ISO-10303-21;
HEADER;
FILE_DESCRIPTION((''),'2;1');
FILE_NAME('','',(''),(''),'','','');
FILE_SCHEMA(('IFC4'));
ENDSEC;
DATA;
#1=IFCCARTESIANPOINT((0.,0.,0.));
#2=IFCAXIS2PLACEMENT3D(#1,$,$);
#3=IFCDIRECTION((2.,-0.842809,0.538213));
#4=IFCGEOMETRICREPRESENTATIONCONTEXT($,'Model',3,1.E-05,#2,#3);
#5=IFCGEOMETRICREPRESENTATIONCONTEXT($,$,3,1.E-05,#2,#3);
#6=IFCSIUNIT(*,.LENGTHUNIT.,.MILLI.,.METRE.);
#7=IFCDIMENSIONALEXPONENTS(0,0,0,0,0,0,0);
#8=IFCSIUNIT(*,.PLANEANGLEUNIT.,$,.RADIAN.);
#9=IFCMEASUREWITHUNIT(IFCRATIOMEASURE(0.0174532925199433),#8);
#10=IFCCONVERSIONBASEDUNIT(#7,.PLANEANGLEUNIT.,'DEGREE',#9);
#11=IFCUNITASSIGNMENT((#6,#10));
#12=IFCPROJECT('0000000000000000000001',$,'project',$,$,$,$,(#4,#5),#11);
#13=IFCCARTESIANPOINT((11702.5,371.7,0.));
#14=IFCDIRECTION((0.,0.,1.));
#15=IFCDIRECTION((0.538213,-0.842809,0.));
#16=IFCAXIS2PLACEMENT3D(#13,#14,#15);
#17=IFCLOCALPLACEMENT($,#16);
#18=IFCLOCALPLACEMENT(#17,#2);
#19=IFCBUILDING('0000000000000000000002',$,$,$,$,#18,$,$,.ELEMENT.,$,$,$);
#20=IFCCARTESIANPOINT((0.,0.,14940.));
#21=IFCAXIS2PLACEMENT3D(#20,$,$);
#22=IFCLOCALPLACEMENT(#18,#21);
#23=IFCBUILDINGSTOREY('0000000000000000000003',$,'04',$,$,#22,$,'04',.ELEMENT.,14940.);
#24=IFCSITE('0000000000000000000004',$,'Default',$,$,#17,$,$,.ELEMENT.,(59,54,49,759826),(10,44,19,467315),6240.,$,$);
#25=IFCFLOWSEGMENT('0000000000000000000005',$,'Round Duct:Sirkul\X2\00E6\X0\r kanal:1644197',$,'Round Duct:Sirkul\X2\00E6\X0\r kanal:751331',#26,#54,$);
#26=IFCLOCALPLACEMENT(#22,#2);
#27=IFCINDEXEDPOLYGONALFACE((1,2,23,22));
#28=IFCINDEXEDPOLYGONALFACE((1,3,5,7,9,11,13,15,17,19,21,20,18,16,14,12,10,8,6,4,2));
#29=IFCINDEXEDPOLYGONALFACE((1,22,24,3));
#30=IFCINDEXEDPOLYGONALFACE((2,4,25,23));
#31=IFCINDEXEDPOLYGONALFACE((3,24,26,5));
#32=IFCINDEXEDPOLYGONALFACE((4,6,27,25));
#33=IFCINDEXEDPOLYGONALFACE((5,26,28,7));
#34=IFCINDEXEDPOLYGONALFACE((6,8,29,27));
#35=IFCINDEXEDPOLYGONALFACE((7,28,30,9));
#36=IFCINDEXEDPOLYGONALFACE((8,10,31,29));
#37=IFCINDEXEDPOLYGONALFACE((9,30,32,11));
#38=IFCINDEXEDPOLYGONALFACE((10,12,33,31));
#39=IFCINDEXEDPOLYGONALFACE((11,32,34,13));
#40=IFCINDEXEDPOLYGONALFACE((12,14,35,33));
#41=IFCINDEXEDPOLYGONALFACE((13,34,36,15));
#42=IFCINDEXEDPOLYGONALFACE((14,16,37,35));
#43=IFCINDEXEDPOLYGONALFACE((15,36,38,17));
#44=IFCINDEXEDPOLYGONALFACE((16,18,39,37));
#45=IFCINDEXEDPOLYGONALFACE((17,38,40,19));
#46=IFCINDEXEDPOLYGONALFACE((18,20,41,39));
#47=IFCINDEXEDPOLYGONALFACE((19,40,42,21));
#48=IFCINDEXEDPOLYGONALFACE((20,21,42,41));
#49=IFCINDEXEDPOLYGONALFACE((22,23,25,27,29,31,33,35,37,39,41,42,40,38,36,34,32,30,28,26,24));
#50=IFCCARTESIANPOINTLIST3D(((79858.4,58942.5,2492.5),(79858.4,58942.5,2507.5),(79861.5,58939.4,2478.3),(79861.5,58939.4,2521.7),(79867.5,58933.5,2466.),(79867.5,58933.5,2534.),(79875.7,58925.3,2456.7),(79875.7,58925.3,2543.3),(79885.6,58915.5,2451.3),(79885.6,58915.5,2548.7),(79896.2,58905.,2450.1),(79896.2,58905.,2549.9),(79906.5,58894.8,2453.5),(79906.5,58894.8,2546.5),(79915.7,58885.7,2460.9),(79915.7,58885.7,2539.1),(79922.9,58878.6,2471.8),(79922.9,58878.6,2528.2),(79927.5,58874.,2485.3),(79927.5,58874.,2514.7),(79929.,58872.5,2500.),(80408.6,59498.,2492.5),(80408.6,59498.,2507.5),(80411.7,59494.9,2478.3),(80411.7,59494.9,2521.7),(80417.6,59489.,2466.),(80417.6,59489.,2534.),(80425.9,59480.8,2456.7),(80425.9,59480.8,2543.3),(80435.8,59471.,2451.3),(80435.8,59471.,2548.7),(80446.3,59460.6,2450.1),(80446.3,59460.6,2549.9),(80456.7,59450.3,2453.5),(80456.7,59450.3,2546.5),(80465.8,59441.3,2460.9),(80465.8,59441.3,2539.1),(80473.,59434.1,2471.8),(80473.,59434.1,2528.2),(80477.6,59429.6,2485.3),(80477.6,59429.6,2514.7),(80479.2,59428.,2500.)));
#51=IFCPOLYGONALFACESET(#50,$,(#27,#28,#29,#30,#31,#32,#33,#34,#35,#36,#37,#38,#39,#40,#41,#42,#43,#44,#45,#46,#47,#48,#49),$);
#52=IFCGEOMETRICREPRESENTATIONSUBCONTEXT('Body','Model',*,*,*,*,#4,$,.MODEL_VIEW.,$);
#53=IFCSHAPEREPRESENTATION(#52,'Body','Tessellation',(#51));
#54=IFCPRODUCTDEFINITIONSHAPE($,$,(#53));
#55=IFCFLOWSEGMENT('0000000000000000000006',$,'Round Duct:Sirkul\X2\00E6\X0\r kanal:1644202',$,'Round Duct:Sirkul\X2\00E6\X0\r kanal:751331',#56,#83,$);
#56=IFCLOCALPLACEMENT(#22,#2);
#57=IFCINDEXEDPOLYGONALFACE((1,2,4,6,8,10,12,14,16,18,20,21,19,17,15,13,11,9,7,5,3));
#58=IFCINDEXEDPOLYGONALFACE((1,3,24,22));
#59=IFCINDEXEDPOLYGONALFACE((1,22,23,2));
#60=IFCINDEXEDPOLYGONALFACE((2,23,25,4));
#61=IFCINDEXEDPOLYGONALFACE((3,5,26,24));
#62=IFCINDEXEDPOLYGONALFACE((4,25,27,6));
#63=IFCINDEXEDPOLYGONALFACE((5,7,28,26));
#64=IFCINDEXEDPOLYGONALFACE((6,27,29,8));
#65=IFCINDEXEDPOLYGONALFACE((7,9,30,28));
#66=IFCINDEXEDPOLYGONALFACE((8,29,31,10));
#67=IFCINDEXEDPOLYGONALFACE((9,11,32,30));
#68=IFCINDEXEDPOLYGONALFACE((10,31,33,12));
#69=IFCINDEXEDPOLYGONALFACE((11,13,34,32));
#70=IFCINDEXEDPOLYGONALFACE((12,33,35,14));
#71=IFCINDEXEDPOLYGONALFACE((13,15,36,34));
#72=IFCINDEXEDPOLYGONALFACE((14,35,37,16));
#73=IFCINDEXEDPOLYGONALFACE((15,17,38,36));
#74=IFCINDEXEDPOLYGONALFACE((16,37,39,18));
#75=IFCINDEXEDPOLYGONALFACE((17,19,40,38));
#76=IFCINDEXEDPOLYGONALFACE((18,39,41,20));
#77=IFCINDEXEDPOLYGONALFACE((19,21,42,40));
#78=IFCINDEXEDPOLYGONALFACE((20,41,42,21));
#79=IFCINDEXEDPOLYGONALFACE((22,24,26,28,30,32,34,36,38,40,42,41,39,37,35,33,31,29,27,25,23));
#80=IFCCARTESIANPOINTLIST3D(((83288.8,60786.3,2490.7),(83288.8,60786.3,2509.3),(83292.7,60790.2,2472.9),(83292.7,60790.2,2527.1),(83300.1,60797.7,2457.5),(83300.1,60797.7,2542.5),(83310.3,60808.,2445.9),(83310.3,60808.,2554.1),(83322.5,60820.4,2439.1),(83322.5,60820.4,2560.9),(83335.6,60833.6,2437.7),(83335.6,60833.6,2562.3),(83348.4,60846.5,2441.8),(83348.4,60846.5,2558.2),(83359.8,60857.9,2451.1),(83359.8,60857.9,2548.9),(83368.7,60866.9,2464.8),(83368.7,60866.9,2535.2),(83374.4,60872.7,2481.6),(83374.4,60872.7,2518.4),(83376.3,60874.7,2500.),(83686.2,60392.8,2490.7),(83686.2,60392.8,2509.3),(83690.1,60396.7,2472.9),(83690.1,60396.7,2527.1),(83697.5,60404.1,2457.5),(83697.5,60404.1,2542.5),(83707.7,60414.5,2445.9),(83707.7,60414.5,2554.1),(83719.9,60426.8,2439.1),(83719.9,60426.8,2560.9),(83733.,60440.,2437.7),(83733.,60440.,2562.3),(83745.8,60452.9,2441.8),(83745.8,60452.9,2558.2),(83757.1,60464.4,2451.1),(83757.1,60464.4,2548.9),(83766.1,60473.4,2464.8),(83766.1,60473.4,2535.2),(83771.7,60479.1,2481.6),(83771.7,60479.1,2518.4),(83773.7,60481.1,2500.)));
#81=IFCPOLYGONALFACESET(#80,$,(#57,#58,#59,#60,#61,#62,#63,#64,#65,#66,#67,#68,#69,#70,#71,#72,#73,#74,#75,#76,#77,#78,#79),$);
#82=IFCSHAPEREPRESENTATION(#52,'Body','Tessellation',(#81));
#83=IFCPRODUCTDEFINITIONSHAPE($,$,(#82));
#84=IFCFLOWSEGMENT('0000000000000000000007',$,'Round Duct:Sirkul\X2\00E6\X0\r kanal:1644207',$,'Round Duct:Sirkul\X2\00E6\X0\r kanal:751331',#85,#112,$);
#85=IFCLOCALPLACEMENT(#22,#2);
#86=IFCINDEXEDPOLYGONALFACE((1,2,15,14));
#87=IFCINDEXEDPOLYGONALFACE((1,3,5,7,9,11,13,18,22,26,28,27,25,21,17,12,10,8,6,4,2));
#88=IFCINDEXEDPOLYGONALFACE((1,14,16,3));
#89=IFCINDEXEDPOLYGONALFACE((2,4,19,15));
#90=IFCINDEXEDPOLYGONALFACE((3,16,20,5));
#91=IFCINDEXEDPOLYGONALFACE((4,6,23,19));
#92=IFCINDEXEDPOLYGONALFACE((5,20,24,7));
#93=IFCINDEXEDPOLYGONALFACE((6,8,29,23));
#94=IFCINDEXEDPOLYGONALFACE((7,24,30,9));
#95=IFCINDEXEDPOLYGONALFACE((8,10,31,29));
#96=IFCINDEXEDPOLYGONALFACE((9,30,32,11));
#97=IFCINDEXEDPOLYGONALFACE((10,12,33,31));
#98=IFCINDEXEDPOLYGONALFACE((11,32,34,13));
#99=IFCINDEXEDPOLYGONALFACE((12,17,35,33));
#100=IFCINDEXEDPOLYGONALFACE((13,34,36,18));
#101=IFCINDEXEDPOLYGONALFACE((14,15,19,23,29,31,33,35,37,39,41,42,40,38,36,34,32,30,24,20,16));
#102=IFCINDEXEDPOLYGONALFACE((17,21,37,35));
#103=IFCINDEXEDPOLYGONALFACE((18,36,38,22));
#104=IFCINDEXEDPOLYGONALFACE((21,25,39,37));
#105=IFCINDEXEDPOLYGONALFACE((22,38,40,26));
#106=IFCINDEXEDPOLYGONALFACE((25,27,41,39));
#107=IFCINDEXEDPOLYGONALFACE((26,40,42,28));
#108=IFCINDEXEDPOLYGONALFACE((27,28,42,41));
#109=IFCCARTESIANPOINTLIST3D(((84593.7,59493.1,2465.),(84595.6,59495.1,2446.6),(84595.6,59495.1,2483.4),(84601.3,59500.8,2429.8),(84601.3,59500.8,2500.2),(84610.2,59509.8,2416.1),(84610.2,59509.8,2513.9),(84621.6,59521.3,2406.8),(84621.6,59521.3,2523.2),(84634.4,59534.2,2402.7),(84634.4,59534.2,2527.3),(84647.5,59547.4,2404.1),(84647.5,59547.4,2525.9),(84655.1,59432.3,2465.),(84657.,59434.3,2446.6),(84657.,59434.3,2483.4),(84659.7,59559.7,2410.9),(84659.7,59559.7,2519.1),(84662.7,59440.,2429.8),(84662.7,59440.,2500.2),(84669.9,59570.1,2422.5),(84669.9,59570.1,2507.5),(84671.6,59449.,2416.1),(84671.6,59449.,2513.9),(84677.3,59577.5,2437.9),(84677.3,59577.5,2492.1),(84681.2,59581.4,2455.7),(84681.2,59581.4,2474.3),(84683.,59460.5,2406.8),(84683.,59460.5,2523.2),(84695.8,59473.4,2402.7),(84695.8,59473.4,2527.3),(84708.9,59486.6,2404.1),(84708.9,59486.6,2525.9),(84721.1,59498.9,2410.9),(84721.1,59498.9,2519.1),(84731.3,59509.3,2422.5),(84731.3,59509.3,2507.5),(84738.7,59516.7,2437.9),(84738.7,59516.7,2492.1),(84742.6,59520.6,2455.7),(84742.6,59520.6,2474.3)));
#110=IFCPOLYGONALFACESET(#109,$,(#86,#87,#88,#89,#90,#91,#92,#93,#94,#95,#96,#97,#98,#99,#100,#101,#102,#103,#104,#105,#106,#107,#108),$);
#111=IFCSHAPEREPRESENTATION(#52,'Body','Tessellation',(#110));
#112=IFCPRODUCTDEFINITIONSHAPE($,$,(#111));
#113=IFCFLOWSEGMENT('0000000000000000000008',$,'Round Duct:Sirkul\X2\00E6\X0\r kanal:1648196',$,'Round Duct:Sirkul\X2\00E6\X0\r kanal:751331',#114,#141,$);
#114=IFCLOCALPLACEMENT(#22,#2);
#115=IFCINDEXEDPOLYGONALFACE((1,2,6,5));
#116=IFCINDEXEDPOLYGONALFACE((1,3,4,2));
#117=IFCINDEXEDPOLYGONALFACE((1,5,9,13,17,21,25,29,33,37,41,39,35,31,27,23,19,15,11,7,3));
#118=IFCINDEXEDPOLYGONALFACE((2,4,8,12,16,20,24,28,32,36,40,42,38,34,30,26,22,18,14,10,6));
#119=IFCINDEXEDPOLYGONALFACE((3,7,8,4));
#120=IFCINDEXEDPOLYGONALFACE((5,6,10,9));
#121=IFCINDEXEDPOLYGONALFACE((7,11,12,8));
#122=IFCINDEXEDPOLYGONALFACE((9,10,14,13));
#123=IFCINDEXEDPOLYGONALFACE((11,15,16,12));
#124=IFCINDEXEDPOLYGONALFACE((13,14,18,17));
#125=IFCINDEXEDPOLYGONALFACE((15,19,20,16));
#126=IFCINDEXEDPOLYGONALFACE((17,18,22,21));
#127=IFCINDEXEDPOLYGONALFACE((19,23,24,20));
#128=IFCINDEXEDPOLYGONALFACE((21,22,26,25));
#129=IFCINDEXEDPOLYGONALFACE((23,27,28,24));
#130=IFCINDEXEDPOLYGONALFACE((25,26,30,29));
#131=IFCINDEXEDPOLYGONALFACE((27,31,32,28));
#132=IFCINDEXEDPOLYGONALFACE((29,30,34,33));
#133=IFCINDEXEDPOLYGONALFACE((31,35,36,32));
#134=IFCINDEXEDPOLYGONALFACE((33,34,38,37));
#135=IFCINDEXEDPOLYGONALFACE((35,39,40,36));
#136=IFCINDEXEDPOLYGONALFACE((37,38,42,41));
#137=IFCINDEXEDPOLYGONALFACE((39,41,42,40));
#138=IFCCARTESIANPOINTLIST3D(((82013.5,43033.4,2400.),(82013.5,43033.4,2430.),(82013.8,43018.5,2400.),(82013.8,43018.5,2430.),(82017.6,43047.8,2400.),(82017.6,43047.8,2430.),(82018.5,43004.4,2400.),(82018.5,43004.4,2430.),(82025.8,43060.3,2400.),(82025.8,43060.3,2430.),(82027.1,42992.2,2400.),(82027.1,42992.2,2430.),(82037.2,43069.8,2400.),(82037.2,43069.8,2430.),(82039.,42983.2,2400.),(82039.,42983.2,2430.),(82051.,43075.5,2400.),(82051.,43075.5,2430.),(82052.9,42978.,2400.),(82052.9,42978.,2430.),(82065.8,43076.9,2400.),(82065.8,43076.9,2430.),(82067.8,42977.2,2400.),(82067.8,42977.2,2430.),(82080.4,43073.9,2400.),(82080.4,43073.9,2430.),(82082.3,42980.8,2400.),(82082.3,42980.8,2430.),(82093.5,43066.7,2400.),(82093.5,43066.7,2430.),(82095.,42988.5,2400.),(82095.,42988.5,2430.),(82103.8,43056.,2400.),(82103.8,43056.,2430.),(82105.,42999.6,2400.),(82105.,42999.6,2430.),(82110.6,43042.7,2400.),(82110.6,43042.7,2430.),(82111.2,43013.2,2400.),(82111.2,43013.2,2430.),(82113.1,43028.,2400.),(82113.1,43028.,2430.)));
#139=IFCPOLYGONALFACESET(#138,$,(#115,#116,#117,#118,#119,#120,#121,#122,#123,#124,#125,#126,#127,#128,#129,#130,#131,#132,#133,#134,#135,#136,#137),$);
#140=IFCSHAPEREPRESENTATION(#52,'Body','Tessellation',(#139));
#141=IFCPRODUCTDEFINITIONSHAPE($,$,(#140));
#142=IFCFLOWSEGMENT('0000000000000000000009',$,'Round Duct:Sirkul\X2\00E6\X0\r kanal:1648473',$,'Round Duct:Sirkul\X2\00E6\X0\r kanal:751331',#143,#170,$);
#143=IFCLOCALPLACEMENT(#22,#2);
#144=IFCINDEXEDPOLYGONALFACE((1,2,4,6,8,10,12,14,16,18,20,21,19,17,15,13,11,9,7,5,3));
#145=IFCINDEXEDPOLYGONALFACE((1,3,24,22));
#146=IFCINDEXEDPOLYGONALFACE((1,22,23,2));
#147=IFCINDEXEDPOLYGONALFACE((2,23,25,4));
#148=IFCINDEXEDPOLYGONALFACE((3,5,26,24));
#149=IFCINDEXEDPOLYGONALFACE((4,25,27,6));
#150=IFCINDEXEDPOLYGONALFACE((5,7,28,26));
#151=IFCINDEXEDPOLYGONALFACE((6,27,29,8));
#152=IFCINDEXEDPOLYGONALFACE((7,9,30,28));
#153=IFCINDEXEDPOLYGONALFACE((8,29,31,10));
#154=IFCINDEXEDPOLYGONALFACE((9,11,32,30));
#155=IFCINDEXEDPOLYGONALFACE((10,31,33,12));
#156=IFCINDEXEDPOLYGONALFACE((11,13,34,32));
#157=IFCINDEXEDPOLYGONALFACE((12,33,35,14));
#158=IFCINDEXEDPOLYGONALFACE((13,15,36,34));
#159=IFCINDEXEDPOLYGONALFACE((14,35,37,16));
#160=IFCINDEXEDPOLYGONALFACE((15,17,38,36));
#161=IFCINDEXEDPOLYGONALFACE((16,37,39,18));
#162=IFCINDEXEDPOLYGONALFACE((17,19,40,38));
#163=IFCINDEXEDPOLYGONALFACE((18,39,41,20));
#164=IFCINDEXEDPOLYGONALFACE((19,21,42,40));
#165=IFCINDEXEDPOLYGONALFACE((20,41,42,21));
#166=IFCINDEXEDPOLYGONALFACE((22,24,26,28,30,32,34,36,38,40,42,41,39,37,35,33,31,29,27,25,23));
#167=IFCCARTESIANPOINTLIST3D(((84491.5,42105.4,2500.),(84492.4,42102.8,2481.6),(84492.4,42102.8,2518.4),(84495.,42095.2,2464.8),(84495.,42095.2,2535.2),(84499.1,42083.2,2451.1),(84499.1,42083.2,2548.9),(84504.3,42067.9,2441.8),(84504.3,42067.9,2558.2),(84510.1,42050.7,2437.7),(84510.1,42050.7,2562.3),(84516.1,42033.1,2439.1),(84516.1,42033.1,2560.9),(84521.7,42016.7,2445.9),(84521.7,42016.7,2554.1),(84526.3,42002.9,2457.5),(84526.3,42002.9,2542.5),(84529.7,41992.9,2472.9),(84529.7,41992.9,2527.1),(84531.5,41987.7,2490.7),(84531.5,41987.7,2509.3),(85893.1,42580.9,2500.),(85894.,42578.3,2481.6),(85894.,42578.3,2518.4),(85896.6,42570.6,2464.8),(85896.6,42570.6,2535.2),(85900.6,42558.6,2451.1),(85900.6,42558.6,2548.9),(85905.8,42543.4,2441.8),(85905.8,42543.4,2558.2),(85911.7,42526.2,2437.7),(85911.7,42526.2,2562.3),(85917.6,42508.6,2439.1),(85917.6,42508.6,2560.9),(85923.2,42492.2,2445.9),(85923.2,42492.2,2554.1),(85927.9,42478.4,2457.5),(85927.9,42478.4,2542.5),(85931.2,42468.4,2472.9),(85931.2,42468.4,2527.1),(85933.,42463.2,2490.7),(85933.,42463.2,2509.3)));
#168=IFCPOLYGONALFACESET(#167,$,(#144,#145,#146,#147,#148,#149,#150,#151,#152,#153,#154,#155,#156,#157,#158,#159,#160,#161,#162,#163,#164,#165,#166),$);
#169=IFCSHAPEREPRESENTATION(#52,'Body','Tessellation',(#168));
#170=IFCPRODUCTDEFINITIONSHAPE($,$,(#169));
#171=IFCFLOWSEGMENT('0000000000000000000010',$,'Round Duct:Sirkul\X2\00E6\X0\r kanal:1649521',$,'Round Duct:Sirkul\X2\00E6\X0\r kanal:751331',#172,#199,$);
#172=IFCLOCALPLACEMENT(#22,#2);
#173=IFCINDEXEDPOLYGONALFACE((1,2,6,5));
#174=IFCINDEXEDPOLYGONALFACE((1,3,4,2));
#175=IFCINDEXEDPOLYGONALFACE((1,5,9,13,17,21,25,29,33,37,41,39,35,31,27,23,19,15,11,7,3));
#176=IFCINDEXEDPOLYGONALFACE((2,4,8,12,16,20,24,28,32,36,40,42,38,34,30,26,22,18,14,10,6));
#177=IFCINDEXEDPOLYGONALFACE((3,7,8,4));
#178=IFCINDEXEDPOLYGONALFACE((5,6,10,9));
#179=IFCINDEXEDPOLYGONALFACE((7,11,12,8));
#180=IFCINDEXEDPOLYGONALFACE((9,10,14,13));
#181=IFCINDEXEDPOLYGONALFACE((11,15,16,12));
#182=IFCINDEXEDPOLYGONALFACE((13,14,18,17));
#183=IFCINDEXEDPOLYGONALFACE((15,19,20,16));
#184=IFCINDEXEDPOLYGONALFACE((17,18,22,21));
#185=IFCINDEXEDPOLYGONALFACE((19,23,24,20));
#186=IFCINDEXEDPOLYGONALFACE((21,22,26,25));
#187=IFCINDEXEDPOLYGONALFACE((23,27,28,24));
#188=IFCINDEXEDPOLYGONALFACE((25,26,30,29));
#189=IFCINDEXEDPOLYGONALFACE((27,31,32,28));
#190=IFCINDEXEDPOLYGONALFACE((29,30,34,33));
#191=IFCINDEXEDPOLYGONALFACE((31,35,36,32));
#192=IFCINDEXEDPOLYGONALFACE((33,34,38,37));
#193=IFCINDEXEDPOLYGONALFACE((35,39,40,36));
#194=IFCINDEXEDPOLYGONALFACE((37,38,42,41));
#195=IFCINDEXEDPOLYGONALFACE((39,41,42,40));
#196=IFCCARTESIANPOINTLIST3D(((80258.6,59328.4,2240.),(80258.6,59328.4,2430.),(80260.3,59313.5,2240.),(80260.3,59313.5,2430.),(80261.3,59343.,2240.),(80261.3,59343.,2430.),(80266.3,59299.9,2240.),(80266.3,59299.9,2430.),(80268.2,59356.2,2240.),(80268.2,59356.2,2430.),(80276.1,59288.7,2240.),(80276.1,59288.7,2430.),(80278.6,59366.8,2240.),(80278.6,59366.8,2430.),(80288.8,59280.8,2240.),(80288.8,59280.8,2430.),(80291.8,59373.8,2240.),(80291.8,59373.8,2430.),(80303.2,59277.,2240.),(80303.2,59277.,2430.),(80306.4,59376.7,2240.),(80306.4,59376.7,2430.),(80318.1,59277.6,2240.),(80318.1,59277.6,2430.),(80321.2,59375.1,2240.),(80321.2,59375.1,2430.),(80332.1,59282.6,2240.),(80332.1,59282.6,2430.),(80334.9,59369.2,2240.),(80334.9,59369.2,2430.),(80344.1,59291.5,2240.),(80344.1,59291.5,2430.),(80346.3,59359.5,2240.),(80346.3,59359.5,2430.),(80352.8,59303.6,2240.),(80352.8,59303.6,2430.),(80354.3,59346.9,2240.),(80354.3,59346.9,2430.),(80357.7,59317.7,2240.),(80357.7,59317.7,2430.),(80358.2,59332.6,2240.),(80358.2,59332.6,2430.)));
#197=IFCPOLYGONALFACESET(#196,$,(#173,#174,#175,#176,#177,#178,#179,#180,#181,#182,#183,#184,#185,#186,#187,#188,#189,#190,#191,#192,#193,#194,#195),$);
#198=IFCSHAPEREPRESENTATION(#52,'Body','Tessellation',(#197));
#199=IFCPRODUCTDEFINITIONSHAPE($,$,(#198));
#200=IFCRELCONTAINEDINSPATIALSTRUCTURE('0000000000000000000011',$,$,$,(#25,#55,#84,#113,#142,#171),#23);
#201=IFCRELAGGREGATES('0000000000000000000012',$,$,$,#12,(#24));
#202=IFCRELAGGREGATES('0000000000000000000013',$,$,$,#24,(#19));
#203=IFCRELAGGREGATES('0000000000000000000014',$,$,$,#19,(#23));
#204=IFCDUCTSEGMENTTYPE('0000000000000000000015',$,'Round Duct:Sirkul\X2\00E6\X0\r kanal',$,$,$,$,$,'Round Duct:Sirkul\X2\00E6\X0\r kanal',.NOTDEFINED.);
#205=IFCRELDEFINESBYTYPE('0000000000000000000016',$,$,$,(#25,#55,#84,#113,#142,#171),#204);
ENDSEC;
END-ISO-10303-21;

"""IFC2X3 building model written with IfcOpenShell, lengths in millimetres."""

from ifc_helpers import new_model, entity, si_unit, converted_unit, direction, frame, frame_2d, origin, origin_2d_with_axis, place, context, subcontext, project, spatial, circle, extrude, type_object, element, save


model = new_model("IFC2X3")

# Units and contexts
model_context = context("Model", 3, precision=1e-05, world=origin(), true_north=direction((2.0, -0.842809, 0.538213)))
context_of_model = context(None, 3, precision=1e-05, world=origin(), true_north=direction((2.0, -0.842809, 0.538213)))
body_context = subcontext(model_context, "Body", "Model", "MODEL_VIEW")
ifc_project = project(units=[si_unit("LENGTHUNIT", "METRE", prefix="MILLI"), converted_unit("PLANEANGLEUNIT", "DEGREE", entity("IfcRatioMeasure", 0.0174532925199433), si_unit("PLANEANGLEUNIT", "RADIAN"), dimensions=[0, 0, 0, 0, 0, 0, 0])], contexts=[model_context, context_of_model])

# Site, building, storey
site_placement = place(None, frame((11702.5, 371.7, 0.0), z_axis=(0.0, 0.0, 1.0), x_axis=(0.538213, -0.842809, 0.0)))
site = spatial("IfcSite", under=ifc_project, at=site_placement, Name="Default", CompositionType="ELEMENT", RefLatitude=(59, 54, 49, 759826), RefLongitude=(10, 44, 19, 467315), RefElevation=6240.0)
building_placement = place(site_placement, origin())
building = spatial("IfcBuilding", under=site, at=building_placement, CompositionType="ELEMENT")
storey_placement = place(building_placement, frame((0.0, 0.0, 14940.0)))
storey = spatial("IfcBuildingStorey", under=building, at=storey_placement, Name="04", LongName="04", CompositionType="ELEMENT", Elevation=14940.0)

# Flow segments
duct_segment_type_1 = type_object("IfcDuctSegmentType", Name="Round Duct:Sirkulær kanal", ElementType="Round Duct:Sirkulær kanal", PredefinedType="NOTDEFINED")
flow_segment_1_placement = place(storey_placement, origin())
element("IfcFlowSegment", 1, at=flow_segment_1_placement, inside=storey, type_object=duct_segment_type_1, Name="Round Duct:Sirkulær kanal:1644197", ObjectType="Round Duct:Sirkulær kanal:751331", context=body_context, shape_type="SweptSolid", body=[
    extrude(circle(Radius=50.0, at=origin_2d_with_axis()), frame((79893.5, 58907.7, 2500.0), z_axis=(0.703669, 0.710528, 0.0), x_axis=(0.710528, -0.703669, 0.0)), (0.0, 0.0, 1.0), 781.9),
])
flow_segment_2_placement = place(storey_placement, origin())
element("IfcFlowSegment", 2, at=flow_segment_2_placement, inside=storey, type_object=duct_segment_type_1, Name="Round Duct:Sirkulær kanal:1644202", ObjectType="Round Duct:Sirkulær kanal:751331", context=body_context, shape_type="SweptSolid", body=[
    extrude(circle(Radius=62.5, at=origin_2d_with_axis()), frame((83332.3, 60830.2, 2500.0), z_axis=(0.710528, -0.703669, 0.0), x_axis=(0.703669, 0.710528, 0.0)), (0.0, 0.0, 1.0), 559.3),
])
flow_segment_3_placement = place(storey_placement, origin())
element("IfcFlowSegment", 3, at=flow_segment_3_placement, inside=storey, type_object=duct_segment_type_1, Name="Round Duct:Sirkulær kanal:1644207", ObjectType="Round Duct:Sirkulær kanal:751331", context=body_context, shape_type="SweptSolid", body=[
    extrude(circle(Radius=62.5, at=origin_2d_with_axis()), frame((84637.7, 59537.5, 2465.0), z_axis=(0.710528, -0.703669, 0.0), x_axis=(-0.703669, -0.710528, 0.0)), (0.0, 0.0, 1.0), 86.4),
])
flow_segment_4_placement = place(storey_placement, origin())
element("IfcFlowSegment", 4, at=flow_segment_4_placement, inside=storey, type_object=duct_segment_type_1, Name="Round Duct:Sirkulær kanal:1648196", ObjectType="Round Duct:Sirkulær kanal:751331", context=body_context, shape_type="SweptSolid", body=[
    extrude(circle(Radius=50.0, at=origin_2d_with_axis()), frame((82063.1, 43027.0, 2400.0), z_axis=(0.0, 0.0, 1.0), x_axis=(0.949546, 0.313626, 0.0)), (0.0, 0.0, 1.0), 30.0),
])
flow_segment_5_placement = place(storey_placement, origin())
element("IfcFlowSegment", 5, at=flow_segment_5_placement, inside=storey, type_object=duct_segment_type_1, Name="Round Duct:Sirkulær kanal:1648473", ObjectType="Round Duct:Sirkulær kanal:751331", context=body_context, shape_type="SweptSolid", body=[
    extrude(circle(Radius=62.5, at=origin_2d_with_axis()), frame((84511.6, 42046.3, 2500.0), z_axis=(0.946986, 0.321276, 0.0), x_axis=(-0.321276, 0.946986, 0.0)), (0.0, 0.0, 1.0), 1480.0),
])
flow_segment_6_placement = place(storey_placement, origin())
element("IfcFlowSegment", 6, at=flow_segment_6_placement, inside=storey, type_object=duct_segment_type_1, Name="Round Duct:Sirkulær kanal:1649521", ObjectType="Round Duct:Sirkulær kanal:751331", context=body_context, shape_type="SweptSolid", body=[
    extrude(circle(Radius=50.0, at=frame_2d((0.0, 0.0), x_axis=(1.0, 0.0))), frame((80308.5, 59326.7, 2240.0), z_axis=(0.0, 0.0, 1.0), x_axis=(0.710528, -0.703669, 0.0)), (0.0, 0.0, 1.0), 190.0),
])

save(model, "model.ifc")
